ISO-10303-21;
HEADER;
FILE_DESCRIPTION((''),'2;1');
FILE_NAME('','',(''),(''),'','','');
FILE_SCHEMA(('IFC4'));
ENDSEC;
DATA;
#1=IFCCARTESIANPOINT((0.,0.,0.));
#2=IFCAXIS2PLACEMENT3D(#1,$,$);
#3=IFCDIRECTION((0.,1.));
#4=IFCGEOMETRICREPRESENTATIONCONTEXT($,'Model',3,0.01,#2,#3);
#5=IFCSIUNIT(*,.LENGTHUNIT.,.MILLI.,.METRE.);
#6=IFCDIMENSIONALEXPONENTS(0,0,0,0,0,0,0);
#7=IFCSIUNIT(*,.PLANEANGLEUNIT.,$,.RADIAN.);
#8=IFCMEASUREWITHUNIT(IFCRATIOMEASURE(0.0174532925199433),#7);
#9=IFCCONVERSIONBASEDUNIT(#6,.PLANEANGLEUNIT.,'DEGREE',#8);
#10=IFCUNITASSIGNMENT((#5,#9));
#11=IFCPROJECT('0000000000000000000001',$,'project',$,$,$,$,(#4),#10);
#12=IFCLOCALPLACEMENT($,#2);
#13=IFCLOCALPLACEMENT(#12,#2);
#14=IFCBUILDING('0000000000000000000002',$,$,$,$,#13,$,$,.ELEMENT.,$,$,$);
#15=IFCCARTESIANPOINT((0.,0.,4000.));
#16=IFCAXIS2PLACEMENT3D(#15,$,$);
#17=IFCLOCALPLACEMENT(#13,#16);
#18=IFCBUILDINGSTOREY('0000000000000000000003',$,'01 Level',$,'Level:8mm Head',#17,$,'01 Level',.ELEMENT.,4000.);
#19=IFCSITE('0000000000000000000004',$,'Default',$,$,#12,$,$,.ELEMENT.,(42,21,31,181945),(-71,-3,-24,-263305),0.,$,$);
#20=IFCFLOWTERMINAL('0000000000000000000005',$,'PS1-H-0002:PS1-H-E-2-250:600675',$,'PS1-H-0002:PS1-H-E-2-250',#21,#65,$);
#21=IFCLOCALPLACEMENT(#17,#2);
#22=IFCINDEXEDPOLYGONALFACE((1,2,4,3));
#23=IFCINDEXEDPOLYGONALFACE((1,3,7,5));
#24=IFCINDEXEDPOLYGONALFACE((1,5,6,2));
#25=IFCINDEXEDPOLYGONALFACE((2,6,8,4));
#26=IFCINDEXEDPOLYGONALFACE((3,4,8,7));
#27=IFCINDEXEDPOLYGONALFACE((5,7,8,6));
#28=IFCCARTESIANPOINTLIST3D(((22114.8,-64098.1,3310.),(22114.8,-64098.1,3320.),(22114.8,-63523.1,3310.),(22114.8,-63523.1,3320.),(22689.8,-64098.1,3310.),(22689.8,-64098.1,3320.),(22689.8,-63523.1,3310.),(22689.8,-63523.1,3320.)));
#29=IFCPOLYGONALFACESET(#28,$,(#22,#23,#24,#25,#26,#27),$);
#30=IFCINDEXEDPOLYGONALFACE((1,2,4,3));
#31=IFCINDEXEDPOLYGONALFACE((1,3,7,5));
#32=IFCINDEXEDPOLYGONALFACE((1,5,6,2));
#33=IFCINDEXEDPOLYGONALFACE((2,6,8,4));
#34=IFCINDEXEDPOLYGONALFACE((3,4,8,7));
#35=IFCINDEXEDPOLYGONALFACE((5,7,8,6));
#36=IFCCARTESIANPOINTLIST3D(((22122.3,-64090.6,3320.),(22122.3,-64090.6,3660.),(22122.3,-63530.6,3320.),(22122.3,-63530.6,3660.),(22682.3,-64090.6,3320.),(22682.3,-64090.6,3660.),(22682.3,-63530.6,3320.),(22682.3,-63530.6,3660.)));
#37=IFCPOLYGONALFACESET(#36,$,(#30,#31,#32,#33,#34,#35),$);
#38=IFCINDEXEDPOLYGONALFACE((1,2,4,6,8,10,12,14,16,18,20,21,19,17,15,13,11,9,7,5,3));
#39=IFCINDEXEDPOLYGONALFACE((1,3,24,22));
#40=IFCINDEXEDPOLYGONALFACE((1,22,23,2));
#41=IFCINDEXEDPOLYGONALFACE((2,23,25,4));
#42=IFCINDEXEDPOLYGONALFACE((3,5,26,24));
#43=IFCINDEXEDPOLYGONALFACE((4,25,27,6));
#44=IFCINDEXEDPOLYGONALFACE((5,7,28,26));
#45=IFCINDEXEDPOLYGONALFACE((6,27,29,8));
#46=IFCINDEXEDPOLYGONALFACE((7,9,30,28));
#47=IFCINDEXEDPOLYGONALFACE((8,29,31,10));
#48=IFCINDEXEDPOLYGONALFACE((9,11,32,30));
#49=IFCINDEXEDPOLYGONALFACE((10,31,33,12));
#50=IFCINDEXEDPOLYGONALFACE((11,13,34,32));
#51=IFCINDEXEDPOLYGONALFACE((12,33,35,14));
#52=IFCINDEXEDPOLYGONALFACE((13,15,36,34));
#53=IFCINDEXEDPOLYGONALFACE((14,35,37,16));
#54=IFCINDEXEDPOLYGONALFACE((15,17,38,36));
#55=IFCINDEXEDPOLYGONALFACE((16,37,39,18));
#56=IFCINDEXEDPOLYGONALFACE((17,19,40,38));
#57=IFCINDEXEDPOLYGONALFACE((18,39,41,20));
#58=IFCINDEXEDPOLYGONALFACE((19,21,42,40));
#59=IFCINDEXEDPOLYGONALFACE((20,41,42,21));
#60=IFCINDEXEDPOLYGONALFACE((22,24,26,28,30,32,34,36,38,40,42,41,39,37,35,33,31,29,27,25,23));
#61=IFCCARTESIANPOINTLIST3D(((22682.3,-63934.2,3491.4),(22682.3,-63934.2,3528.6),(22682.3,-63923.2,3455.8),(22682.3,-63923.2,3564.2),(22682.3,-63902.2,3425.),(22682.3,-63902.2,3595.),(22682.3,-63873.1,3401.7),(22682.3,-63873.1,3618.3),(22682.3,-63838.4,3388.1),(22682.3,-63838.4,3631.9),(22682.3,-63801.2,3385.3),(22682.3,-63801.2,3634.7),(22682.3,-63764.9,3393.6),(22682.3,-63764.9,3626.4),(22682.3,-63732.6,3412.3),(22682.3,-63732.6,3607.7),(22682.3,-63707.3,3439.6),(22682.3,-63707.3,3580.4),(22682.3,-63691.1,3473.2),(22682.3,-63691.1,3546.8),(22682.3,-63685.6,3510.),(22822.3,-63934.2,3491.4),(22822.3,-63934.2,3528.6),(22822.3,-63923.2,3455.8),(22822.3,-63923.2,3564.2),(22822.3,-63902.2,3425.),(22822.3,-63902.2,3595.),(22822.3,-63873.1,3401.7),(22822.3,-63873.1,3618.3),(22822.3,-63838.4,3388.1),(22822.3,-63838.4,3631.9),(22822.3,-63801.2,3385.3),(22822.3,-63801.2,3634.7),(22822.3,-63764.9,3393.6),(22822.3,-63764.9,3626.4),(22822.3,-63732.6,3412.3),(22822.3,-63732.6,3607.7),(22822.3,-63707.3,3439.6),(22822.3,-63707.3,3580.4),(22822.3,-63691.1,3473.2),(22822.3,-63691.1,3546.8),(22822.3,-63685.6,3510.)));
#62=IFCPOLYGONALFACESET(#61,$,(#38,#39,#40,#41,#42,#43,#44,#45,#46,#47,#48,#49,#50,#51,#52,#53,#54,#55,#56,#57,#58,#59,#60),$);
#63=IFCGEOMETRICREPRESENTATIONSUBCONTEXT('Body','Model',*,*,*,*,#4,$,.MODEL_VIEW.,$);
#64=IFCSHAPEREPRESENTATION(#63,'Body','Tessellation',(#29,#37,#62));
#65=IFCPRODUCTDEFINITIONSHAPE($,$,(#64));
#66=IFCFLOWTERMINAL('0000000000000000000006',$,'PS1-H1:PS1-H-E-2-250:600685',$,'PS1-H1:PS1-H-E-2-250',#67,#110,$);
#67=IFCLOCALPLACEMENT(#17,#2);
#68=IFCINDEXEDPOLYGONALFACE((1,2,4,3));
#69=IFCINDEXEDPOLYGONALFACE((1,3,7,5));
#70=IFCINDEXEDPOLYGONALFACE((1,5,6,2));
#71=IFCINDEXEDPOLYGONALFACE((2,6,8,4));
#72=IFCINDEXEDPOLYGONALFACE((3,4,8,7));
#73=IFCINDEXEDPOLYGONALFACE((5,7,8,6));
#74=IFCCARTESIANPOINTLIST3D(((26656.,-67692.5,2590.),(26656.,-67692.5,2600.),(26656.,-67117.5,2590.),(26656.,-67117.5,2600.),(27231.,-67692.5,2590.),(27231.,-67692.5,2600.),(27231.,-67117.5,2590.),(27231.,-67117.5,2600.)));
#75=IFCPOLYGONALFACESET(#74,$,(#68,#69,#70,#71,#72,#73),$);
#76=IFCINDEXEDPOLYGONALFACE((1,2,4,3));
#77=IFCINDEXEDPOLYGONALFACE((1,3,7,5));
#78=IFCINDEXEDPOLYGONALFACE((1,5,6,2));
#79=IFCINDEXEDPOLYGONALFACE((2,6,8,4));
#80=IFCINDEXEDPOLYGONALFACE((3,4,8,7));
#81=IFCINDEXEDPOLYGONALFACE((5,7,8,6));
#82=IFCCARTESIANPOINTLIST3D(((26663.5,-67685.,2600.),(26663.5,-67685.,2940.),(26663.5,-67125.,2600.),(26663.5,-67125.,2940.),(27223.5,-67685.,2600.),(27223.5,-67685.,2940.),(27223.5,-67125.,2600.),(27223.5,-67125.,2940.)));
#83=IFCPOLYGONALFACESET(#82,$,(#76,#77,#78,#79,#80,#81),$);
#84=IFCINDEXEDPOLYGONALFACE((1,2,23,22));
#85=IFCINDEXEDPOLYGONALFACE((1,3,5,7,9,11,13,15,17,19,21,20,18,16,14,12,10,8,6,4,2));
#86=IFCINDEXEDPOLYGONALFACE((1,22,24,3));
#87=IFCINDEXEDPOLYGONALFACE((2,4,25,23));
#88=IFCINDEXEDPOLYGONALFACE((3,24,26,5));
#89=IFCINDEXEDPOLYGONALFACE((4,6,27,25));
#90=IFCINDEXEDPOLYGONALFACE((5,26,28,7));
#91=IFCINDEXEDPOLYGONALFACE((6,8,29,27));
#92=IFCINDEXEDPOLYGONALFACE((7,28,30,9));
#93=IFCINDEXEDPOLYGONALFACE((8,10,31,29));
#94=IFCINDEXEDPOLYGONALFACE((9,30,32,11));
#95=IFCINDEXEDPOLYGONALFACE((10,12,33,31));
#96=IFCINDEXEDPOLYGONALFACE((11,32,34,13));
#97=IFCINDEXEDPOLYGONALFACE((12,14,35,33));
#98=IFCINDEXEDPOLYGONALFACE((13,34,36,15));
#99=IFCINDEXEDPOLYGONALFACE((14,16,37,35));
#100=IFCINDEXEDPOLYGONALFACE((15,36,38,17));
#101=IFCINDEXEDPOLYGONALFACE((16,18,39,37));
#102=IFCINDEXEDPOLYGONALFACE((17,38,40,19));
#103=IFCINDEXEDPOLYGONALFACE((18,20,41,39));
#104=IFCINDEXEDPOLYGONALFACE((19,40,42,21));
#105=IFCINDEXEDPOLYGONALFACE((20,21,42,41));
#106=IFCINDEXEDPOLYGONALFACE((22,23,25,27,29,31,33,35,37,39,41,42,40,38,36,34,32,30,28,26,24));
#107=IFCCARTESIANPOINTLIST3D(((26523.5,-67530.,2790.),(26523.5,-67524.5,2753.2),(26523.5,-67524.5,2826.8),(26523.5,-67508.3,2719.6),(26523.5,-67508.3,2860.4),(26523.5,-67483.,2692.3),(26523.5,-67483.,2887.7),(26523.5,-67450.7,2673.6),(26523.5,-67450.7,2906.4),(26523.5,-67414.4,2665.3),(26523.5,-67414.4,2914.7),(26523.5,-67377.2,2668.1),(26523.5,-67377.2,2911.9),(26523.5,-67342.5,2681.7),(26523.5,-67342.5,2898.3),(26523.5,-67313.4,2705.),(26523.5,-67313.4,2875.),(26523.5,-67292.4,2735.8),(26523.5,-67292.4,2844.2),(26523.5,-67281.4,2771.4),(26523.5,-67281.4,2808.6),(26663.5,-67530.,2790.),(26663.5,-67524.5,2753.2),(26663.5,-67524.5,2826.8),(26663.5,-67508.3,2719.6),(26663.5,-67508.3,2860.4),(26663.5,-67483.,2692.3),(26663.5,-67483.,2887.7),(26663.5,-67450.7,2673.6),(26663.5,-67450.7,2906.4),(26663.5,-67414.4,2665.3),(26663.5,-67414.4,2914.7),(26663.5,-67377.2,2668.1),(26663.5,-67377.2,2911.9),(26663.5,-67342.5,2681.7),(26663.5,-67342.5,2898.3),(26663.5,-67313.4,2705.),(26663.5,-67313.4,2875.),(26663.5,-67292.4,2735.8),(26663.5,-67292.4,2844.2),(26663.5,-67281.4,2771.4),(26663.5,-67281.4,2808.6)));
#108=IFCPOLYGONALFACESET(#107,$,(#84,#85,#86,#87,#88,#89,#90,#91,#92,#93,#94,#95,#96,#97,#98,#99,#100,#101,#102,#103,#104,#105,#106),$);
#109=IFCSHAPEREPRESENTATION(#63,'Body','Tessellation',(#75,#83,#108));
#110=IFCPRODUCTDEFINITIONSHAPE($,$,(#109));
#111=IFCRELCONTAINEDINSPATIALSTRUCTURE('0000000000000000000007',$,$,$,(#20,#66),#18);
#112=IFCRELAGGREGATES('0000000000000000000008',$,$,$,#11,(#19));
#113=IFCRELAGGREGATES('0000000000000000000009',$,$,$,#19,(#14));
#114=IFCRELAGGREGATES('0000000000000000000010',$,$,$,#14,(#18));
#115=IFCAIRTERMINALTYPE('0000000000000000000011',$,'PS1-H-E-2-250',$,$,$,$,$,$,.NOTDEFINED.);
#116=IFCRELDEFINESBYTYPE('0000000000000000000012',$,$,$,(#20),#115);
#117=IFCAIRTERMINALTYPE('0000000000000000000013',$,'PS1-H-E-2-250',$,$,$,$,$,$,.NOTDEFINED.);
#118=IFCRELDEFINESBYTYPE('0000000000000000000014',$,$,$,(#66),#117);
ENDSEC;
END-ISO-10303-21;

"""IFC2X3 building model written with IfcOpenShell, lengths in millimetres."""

from ifc_helpers import new_model, entity, si_unit, converted_unit, direction, frame, frame_2d, origin, origin_2d_with_axis, place, context, subcontext, project, spatial, rectangle, circle, extrude, source, transform, mapped, type_object, type_shapes, element, save


model = new_model("IFC2X3")

# Units and contexts
model_context = context("Model", 3, precision=0.01, world=origin(), true_north=direction((0.0, 1.0)))
body_context = subcontext(model_context, "Body", "Model", "MODEL_VIEW")
ifc_project = project(units=[si_unit("LENGTHUNIT", "METRE", prefix="MILLI"), converted_unit("PLANEANGLEUNIT", "DEGREE", entity("IfcRatioMeasure", 0.0174532925199433), si_unit("PLANEANGLEUNIT", "RADIAN"), dimensions=[0, 0, 0, 0, 0, 0, 0])], contexts=[model_context])

# Site, building, storey
site_placement = place(None, origin())
site = spatial("IfcSite", under=ifc_project, at=site_placement, Name="Default", CompositionType="ELEMENT", RefLatitude=(42, 21, 31, 181945), RefLongitude=(-71, -3, -24, -263305), RefElevation=0.0)
building_placement = place(site_placement, origin())
building = spatial("IfcBuilding", under=site, at=building_placement, CompositionType="ELEMENT")
storey_placement = place(building_placement, frame((0.0, 0.0, 4000.0)))
storey = spatial("IfcBuildingStorey", under=building, at=storey_placement, Name="01 Level", ObjectType="Level:8mm Head", LongName="01 Level", CompositionType="ELEMENT", Elevation=4000.0)

# Flow terminals
air_terminal_type_1 = type_object("IfcAirTerminalType", Name="PS1-H-E-2-250", PredefinedType="NOTDEFINED")
shared_shape_1 = source(origin(), body_context, "Body", "SweptSolid", [
    extrude(rectangle(XDim=575.0, YDim=575.0, at=origin_2d_with_axis()), frame((0.0, 0.0, -10.0), z_axis=(0.0, 0.0, 1.0), x_axis=(0.0, 1.0, 0.0)), (0.0, 0.0, 1.0), 10.0),
    extrude(rectangle(XDim=560.0, YDim=560.0, at=origin_2d_with_axis()), frame((0.0, 0.0, 0.0), z_axis=(0.0, 0.0, 1.0), x_axis=(0.0, 1.0, 0.0)), (0.0, 0.0, 1.0), 340.0),
    extrude(circle(Radius=125.0, at=frame_2d((0.0, 0.0), x_axis=(1.0, 0.0))), frame((-420.0, 0.0, 190.0), z_axis=(1.0, 0.0, 0.0), x_axis=(0.0, -1.0, 0.0)), (0.0, 0.0, 1.0), 140.0),
])
type_shapes(air_terminal_type_1, [shared_shape_1])
flow_terminal_1_placement = place(storey_placement, frame((22402.3, -63810.6, 3320.0), z_axis=(0.0, 0.0, 1.0), x_axis=(-1.0, 0.0, 0.0)))
element("IfcFlowTerminal", 1, at=flow_terminal_1_placement, inside=storey, type_object=air_terminal_type_1, Name="PS1-H-0002:PS1-H-E-2-250:600675", ObjectType="PS1-H-0002:PS1-H-E-2-250", context=body_context, shape_type="MappedRepresentation", body=[
    mapped(shared_shape_1, transform((0.0, 0.0, 0.0), scale=1.0)),
])
air_terminal_type_2 = type_object("IfcAirTerminalType", Name="PS1-H-E-2-250", PredefinedType="NOTDEFINED")
shared_shape_2 = source(origin(), body_context, "Body", "SweptSolid", [
    extrude(rectangle(XDim=575.0, YDim=575.0, at=origin_2d_with_axis()), frame((0.0, 0.0, -10.0), z_axis=(0.0, 0.0, 1.0), x_axis=(0.0, 1.0, 0.0)), (0.0, 0.0, 1.0), 10.0),
    extrude(rectangle(XDim=560.0, YDim=560.0, at=origin_2d_with_axis()), frame((0.0, 0.0, 0.0), z_axis=(0.0, 0.0, 1.0), x_axis=(0.0, 1.0, 0.0)), (0.0, 0.0, 1.0), 340.0),
    extrude(circle(Radius=125.0, at=frame_2d((0.0, 0.0), x_axis=(1.0, 0.0))), frame((-420.0, 0.0, 190.0), z_axis=(1.0, 0.0, 0.0), x_axis=(0.0, -1.0, 0.0)), (0.0, 0.0, 1.0), 140.0),
])
type_shapes(air_terminal_type_2, [shared_shape_2])
flow_terminal_2_placement = place(storey_placement, frame((26943.5, -67405.0, 2600.0)))
element("IfcFlowTerminal", 2, at=flow_terminal_2_placement, inside=storey, type_object=air_terminal_type_2, Name="PS1-H1:PS1-H-E-2-250:600685", ObjectType="PS1-H1:PS1-H-E-2-250", context=body_context, shape_type="MappedRepresentation", body=[
    mapped(shared_shape_2, transform((0.0, 0.0, 0.0), scale=1.0)),
])

save(model, "model.ifc")
